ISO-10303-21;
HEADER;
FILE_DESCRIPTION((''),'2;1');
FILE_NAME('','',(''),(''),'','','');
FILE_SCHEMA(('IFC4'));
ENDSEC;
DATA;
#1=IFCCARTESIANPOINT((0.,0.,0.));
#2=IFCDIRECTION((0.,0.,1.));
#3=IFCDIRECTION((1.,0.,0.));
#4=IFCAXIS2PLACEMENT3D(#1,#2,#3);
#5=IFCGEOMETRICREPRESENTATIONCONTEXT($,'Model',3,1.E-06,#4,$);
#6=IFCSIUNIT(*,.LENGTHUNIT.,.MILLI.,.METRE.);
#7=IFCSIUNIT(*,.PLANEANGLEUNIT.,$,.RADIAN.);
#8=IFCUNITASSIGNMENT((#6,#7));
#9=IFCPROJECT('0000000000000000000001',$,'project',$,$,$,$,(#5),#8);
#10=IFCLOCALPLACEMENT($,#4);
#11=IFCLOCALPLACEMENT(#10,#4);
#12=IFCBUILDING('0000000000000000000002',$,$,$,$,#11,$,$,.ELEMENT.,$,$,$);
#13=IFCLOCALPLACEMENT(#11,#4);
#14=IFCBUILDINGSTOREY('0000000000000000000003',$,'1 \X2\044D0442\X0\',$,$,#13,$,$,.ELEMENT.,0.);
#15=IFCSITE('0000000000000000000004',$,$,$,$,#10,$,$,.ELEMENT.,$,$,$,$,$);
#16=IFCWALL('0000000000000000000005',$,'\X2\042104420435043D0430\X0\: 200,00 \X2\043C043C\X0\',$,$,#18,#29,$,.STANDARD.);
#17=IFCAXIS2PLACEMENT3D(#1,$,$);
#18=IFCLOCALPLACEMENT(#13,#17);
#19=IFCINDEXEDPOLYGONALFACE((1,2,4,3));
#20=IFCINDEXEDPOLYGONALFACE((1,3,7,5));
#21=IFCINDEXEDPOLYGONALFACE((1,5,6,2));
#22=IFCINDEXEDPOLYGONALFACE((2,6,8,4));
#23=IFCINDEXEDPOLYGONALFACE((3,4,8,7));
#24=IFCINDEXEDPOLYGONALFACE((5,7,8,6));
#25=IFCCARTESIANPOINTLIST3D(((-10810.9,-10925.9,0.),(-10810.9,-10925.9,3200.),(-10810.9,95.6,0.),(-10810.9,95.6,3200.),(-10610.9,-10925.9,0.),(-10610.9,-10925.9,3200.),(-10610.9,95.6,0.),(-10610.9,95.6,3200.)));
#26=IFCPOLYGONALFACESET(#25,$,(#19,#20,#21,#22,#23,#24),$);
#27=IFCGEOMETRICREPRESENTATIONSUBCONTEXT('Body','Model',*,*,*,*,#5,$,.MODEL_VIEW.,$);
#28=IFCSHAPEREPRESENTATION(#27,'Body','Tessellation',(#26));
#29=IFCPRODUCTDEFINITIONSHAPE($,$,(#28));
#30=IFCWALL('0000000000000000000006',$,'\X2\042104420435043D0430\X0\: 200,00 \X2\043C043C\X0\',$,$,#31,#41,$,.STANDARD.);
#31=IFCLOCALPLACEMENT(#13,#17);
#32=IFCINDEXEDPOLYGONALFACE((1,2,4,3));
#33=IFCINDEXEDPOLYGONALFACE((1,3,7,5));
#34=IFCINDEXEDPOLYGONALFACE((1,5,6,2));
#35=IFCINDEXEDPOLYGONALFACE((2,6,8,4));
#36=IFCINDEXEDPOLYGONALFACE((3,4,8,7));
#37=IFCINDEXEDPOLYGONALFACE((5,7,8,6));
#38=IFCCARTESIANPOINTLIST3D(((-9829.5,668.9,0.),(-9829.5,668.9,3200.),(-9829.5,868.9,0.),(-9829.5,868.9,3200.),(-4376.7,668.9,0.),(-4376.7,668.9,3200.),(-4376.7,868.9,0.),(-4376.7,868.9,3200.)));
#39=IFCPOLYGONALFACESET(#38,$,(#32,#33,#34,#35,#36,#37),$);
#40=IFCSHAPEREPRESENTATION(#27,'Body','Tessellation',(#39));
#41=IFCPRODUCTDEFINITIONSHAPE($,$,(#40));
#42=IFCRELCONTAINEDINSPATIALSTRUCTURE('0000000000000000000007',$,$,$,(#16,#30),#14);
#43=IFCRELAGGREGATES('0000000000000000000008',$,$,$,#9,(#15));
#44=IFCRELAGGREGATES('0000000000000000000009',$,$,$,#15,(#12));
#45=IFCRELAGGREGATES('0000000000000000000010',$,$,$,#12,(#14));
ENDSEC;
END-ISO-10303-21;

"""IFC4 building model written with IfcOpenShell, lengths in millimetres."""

from ifc_helpers import new_model, si_unit, frame, origin_with_axes, place, context, subcontext, project, spatial, line, indexed_curve, outline, extrude, source, transform, mapped, element, save


model = new_model("IFC4")

# Units and contexts
model_context = context("Model", 3, precision=1e-06, world=origin_with_axes())
body_context = subcontext(model_context, "Body", "Model", "MODEL_VIEW")
ifc_project = project(units=[si_unit("LENGTHUNIT", "METRE", prefix="MILLI"), si_unit("PLANEANGLEUNIT", "RADIAN")], contexts=[model_context])

# Site, building, storey
site_placement = place(None, origin_with_axes())
site = spatial("IfcSite", under=ifc_project, at=site_placement, CompositionType="ELEMENT")
building_placement = place(site_placement, origin_with_axes())
building = spatial("IfcBuilding", under=site, at=building_placement, CompositionType="ELEMENT")
storey_placement = place(building_placement, origin_with_axes())
storey = spatial("IfcBuildingStorey", under=building, at=storey_placement, Name="1 эт", CompositionType="ELEMENT", Elevation=0.0)

# Walls
shared_shape_1 = source(origin_with_axes(), body_context, "Body", "SweptSolid", [
    extrude(outline(indexed_curve([(0.0, -100.0), (11021.5, -100.0), (11021.5, 100.0), (0.0, 100.0)], segments=[line(1, 2), line(2, 3), line(3, 4), line(4, 1)])), origin_with_axes(), (0.0, 0.0, 1.0), 3200.0),
])
wall_1_placement = place(storey_placement, frame((-10710.9, -10925.9, 0.0), z_axis=(0.0, 0.0, 1.0), x_axis=(0.0, 1.0, 0.0)))
element("IfcWall", 1, at=wall_1_placement, inside=storey, Name="Стена: 200,00 мм", PredefinedType="STANDARD", context=body_context, shape_type="MappedRepresentation", body=[
    mapped(shared_shape_1, transform((0.0, 0.0, 0.0), x_axis=(1.0, 0.0, 0.0), y_axis=(0.0, 1.0, 0.0), z_axis=(0.0, 0.0, 1.0), scale=1.0)),
])
shared_shape_2 = source(origin_with_axes(), body_context, "Body", "SweptSolid", [
    extrude(outline(indexed_curve([(0.0, -100.0), (5452.8, -100.0), (5452.8, 100.0), (0.0, 100.0)], segments=[line(1, 2), line(2, 3), line(3, 4), line(4, 1)])), origin_with_axes(), (0.0, 0.0, 1.0), 3200.0),
])
wall_2_placement = place(storey_placement, frame((-9829.5, 768.9, 0.0), z_axis=(0.0, 0.0, 1.0), x_axis=(1.0, 0.0, 0.0)))
element("IfcWall", 2, at=wall_2_placement, inside=storey, Name="Стена: 200,00 мм", PredefinedType="STANDARD", context=body_context, shape_type="MappedRepresentation", body=[
    mapped(shared_shape_2, transform((0.0, 0.0, 0.0), x_axis=(1.0, 0.0, 0.0), y_axis=(0.0, 1.0, 0.0), z_axis=(0.0, 0.0, 1.0), scale=1.0)),
])

save(model, "model.ifc")
